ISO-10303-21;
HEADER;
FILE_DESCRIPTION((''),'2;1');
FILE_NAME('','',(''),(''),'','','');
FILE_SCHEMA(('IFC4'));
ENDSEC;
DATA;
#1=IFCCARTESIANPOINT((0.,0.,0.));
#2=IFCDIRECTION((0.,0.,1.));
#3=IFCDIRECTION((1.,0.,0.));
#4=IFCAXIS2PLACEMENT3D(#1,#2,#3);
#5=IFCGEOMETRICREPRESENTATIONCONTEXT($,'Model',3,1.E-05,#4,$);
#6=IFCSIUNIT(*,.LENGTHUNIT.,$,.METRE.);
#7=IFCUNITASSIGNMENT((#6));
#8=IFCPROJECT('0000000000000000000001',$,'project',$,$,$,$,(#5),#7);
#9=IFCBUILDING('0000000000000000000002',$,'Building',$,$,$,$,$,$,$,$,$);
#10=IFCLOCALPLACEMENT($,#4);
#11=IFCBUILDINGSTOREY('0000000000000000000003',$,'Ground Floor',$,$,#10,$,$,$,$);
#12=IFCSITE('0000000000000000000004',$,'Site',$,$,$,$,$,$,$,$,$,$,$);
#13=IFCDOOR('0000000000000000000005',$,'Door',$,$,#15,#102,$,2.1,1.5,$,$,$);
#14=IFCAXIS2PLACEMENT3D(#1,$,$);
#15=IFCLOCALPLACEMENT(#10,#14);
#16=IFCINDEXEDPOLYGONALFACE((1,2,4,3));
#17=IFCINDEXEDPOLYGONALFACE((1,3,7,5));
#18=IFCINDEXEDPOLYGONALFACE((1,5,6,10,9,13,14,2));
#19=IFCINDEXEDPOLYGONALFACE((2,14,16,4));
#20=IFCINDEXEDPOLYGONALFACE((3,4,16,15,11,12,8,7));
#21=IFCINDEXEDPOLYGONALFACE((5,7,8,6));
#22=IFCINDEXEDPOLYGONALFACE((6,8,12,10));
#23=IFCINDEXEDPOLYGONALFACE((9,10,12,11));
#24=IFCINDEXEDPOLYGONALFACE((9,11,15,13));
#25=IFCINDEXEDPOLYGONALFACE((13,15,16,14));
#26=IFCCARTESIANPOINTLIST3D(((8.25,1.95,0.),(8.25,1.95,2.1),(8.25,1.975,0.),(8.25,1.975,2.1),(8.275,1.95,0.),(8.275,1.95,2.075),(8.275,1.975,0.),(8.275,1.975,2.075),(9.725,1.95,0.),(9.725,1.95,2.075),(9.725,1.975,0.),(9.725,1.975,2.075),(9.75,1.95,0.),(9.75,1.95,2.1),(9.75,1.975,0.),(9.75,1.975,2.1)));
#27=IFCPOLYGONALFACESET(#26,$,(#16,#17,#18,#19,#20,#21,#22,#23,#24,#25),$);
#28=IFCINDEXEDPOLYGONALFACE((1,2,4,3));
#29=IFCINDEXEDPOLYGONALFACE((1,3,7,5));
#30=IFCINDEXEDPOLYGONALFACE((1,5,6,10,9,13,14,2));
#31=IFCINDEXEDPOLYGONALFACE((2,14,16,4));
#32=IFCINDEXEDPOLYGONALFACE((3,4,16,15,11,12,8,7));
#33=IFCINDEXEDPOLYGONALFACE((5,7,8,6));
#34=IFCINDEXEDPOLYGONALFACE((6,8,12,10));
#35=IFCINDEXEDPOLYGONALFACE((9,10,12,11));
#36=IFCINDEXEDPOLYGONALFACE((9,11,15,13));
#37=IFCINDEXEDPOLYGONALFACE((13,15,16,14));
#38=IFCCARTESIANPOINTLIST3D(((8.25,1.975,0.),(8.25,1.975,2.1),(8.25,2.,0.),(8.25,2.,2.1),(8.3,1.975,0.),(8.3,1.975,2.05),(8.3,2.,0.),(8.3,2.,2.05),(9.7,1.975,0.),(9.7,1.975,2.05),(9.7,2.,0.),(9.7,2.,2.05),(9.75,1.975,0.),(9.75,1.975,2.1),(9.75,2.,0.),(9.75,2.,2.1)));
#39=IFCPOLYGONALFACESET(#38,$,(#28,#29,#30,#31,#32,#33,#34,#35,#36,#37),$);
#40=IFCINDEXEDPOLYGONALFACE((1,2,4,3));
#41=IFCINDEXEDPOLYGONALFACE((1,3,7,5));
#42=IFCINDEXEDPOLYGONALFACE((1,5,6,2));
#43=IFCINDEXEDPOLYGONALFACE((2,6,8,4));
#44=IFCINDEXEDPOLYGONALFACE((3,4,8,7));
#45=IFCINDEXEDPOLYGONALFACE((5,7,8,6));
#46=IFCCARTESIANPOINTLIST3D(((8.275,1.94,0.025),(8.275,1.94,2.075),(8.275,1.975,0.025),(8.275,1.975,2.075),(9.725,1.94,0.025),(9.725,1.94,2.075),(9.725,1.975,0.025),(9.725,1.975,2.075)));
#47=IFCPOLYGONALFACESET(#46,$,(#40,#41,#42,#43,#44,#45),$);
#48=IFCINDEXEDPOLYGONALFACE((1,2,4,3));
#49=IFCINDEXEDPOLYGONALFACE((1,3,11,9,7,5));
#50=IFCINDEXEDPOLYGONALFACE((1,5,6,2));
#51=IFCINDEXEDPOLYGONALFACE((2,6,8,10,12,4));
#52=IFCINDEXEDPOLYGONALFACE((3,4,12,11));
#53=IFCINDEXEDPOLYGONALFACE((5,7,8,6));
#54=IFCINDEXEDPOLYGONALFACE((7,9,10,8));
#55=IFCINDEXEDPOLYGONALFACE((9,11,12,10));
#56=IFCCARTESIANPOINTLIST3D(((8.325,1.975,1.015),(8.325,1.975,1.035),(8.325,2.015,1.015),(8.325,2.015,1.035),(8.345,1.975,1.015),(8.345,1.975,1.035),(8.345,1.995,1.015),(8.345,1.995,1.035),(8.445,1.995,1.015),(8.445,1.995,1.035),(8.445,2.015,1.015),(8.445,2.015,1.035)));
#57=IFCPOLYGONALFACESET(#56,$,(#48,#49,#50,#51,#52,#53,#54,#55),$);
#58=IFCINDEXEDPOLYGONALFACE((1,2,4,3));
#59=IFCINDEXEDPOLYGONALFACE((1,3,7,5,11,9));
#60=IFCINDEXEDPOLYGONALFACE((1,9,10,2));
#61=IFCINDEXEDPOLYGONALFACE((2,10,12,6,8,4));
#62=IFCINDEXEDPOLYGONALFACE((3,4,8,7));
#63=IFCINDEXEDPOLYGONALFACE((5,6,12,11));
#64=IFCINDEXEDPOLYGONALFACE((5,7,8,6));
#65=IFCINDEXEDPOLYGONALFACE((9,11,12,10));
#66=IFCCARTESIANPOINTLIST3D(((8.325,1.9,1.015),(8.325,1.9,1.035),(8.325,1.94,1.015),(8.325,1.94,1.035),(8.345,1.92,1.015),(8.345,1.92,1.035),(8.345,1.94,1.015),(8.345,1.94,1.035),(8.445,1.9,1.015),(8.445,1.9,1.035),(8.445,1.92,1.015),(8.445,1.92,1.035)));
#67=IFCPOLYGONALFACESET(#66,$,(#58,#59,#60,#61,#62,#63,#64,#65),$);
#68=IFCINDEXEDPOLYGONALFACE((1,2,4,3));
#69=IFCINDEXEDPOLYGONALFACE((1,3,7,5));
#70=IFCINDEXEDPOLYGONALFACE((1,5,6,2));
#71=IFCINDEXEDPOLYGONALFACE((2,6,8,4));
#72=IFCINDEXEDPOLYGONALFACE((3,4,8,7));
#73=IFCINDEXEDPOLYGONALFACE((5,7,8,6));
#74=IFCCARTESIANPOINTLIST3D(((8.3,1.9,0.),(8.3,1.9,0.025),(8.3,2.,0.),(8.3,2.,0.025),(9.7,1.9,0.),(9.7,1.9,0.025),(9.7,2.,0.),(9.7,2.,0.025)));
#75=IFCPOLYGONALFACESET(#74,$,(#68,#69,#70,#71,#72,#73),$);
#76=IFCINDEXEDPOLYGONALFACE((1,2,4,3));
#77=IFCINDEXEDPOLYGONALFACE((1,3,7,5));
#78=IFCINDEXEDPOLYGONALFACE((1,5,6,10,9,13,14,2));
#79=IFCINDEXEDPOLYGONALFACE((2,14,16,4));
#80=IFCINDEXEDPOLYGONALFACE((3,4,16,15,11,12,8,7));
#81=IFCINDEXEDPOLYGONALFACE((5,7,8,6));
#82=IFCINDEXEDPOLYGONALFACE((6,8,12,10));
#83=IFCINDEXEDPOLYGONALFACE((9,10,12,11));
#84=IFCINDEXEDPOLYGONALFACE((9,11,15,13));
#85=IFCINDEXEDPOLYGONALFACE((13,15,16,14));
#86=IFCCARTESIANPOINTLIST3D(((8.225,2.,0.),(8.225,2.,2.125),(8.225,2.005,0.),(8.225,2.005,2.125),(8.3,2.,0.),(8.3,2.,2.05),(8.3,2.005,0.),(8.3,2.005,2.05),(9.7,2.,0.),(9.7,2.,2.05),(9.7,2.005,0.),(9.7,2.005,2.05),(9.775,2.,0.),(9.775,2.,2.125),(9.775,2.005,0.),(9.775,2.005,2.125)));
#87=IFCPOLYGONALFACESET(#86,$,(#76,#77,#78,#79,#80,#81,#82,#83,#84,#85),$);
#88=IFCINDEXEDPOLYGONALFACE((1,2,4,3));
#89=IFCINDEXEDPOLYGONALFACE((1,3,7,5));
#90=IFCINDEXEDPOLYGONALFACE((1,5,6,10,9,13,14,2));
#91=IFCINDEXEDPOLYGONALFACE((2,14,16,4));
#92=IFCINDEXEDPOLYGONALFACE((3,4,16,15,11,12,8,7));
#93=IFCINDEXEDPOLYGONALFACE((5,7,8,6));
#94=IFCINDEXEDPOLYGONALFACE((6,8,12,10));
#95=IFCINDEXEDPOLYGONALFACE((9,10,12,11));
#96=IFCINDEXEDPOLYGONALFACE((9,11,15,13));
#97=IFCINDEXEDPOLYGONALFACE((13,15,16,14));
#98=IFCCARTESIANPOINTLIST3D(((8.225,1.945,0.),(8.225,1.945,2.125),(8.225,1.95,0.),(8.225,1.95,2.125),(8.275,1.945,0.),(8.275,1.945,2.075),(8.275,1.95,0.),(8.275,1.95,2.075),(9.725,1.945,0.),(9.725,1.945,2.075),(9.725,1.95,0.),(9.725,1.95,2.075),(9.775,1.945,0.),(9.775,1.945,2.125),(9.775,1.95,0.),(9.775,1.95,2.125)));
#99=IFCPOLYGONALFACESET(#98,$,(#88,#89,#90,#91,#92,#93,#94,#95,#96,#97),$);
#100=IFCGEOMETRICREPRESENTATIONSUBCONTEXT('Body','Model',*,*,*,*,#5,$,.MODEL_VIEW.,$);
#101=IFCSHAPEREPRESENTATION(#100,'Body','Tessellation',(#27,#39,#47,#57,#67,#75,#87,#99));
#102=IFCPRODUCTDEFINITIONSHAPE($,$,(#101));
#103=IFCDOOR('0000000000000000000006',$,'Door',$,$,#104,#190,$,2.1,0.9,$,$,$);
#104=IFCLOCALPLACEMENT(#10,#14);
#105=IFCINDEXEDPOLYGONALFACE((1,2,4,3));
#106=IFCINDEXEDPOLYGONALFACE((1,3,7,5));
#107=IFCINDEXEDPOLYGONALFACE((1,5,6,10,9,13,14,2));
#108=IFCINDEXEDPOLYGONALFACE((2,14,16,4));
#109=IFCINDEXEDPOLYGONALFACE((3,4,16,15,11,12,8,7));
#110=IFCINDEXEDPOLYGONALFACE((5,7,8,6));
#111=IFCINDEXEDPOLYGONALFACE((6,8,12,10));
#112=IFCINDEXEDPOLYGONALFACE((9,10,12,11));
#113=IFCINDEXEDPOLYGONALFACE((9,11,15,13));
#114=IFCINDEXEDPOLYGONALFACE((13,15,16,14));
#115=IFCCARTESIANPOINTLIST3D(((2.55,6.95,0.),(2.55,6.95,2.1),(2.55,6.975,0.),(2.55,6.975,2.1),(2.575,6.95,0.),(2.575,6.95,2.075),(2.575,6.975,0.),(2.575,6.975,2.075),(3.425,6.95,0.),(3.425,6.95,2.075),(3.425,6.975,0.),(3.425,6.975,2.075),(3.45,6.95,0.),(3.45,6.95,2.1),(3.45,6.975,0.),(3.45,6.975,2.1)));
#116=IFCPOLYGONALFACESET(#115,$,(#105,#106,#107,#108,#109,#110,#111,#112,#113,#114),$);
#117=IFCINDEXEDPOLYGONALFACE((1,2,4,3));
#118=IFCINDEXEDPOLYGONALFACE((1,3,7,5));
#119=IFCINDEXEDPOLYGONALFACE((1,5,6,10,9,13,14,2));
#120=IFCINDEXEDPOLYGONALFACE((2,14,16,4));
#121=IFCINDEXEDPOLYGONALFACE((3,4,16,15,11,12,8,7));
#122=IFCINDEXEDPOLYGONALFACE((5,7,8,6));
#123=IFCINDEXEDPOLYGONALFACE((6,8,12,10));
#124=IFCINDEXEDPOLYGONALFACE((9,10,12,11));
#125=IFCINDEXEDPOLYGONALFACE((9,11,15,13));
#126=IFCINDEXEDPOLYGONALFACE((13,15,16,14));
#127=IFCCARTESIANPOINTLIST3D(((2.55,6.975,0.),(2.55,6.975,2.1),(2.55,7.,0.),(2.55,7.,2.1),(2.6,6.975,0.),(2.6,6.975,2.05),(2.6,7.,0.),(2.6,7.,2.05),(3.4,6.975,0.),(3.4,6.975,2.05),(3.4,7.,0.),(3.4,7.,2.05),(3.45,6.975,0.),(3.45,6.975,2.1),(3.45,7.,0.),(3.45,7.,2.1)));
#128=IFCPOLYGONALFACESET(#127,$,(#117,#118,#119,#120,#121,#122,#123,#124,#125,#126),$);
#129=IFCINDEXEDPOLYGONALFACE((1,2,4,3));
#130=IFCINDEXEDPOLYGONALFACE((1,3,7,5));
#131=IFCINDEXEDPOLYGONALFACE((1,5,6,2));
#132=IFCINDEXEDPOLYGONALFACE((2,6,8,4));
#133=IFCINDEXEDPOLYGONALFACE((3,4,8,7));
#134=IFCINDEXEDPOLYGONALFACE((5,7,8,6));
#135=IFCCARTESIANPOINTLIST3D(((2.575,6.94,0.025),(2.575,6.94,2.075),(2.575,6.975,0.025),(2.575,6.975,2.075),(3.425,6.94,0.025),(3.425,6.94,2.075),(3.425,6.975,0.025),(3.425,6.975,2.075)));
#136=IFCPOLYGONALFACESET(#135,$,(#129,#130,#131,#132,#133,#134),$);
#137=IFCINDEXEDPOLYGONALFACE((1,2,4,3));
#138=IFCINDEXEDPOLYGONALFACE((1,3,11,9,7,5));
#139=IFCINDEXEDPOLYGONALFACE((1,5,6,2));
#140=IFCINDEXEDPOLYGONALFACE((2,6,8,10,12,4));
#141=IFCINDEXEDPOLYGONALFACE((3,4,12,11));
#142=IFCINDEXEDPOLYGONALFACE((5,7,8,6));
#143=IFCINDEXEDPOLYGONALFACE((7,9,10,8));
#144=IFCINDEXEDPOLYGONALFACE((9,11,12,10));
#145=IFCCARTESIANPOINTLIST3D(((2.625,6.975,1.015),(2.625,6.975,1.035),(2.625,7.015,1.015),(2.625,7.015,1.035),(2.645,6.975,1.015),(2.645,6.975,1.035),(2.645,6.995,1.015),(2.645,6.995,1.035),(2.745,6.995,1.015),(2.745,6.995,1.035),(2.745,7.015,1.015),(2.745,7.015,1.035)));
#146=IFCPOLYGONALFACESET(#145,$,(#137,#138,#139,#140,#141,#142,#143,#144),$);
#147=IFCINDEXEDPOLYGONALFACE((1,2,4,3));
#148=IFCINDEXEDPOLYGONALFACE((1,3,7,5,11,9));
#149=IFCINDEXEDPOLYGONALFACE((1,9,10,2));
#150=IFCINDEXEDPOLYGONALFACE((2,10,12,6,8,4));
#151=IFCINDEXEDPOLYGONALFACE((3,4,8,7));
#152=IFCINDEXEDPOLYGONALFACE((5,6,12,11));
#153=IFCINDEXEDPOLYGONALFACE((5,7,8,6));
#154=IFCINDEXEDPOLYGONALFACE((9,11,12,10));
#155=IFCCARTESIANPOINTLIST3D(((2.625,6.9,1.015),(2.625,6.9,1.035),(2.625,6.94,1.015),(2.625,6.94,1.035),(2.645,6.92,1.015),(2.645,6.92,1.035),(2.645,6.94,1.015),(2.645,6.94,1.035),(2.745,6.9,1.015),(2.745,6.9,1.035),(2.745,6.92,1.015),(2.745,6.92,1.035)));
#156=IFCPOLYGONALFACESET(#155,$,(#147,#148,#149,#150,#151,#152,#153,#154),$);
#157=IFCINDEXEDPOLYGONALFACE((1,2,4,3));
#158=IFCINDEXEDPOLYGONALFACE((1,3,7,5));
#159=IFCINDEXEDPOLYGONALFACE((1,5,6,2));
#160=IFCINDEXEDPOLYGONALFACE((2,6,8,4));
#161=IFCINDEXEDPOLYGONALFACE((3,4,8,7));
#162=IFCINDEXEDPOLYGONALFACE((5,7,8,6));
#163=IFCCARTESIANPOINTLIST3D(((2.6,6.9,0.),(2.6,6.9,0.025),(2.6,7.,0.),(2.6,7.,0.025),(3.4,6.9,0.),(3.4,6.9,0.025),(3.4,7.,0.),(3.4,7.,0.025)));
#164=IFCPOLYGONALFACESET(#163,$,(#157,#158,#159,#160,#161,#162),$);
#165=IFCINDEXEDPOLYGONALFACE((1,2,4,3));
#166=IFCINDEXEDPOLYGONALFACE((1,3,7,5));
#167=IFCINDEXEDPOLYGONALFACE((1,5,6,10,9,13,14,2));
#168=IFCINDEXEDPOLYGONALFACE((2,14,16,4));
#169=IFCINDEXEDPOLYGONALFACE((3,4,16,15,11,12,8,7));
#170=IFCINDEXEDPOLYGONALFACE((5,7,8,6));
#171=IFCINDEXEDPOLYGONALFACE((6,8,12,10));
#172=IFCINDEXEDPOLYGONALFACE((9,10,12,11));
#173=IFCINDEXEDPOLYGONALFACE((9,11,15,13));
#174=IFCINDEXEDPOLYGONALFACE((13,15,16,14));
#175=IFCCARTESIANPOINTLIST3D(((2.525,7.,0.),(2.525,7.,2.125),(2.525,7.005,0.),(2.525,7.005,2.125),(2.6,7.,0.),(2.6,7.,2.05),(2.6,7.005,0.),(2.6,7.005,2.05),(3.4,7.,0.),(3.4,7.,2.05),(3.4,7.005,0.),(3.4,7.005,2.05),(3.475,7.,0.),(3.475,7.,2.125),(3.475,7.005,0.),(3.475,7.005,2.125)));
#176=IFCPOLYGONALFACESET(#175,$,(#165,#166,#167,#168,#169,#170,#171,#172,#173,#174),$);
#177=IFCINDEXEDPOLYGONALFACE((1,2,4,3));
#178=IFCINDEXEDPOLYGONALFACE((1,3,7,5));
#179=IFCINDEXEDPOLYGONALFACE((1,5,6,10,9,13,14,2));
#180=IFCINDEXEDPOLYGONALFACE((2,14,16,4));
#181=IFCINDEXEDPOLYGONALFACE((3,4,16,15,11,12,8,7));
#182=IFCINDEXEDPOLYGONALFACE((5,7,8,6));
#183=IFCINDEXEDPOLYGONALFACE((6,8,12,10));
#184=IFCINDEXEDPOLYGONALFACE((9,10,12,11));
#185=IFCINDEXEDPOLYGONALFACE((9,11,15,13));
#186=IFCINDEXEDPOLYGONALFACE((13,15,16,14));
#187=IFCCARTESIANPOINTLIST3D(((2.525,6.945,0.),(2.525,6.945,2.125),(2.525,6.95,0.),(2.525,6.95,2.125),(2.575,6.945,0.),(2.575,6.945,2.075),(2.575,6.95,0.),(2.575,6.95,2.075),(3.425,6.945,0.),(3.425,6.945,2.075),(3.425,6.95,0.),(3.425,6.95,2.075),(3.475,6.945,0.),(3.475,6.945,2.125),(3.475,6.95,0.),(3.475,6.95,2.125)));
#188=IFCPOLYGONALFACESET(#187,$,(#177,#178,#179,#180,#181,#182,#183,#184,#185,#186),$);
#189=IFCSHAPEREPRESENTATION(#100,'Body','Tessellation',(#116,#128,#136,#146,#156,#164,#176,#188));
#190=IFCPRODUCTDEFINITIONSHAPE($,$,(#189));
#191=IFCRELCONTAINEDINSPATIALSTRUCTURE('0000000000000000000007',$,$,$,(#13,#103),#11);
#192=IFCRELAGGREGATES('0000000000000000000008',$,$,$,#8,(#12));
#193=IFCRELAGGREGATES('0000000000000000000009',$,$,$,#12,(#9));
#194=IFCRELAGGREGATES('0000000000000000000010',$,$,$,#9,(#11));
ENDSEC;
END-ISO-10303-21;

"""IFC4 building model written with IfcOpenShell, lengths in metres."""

from ifc_helpers import new_model, si_unit, frame, origin_with_axes, place, context, subcontext, project, spatial, line, indexed_curve, outline, extrude, element, save


model = new_model("IFC4")

# Units and contexts
model_context = context("Model", 3, precision=1e-05, world=origin_with_axes())
body_context = subcontext(model_context, "Body", "Model", "MODEL_VIEW")
ifc_project = project(units=[si_unit("LENGTHUNIT", "METRE")], contexts=[model_context])

# Site, building, storey
site = spatial("IfcSite", under=ifc_project, Name="Site")
building = spatial("IfcBuilding", under=site, Name="Building")
storey_placement = place(None, origin_with_axes())
storey = spatial("IfcBuildingStorey", under=building, at=storey_placement, Name="Ground Floor")

# Doors
door_1_placement = place(storey_placement, frame((9.75, 2.0, 0.0), z_axis=(0.0, 0.0, 1.0), x_axis=(-1.0, 0.0, 0.0)))
element("IfcDoor", 1, at=door_1_placement, inside=storey, Name="Door", OverallHeight=2.1, OverallWidth=1.5, context=body_context, shape_type="SweptSolid", body=[
    extrude(outline(indexed_curve([(0.0, 0.0), (0.0, 2.1), (1.5, 2.1), (1.5, 0.0), (1.475, 0.0), (1.475, 2.075), (0.025, 2.075), (0.025, 0.0)], segments=[line(1, 2, 3, 4, 5, 6, 7, 8, 1)])), frame((0.0, 0.025, 0.0), z_axis=(0.0, -1.0, 0.0), x_axis=(1.0, 0.0, 0.0)), (0.0, 0.0, -1.0), 0.025),
    extrude(outline(indexed_curve([(0.0, 0.0), (0.0, 2.1), (1.5, 2.1), (1.5, 0.0), (1.45, 0.0), (1.45, 2.05), (0.05, 2.05), (0.05, 0.0)], segments=[line(1, 2, 3, 4, 5, 6, 7, 8, 1)])), frame((0.0, 0.0, 0.0), z_axis=(0.0, -1.0, 0.0), x_axis=(1.0, 0.0, 0.0)), (0.0, 0.0, -1.0), 0.025),
    extrude(outline(indexed_curve([(0.0, 0.0), (1.45, 0.0), (1.45, 0.035), (0.0, 0.035)], segments=[line(1, 2, 3, 4, 1)])), frame((0.025, 0.025, 0.025), z_axis=(0.0, 0.0, 1.0), x_axis=(1.0, 0.0, 0.0)), (0.0, 0.0, 1.0), 2.05),
    extrude(outline(indexed_curve([(0.0, 0.0), (0.0, -0.04), (-0.12, -0.04), (-0.12, -0.02), (-0.02, -0.02), (-0.02, 0.0)], segments=[line(1, 2, 3, 4, 5, 6, 1)])), frame((1.425, 0.025, 1.015), z_axis=(0.0, 0.0, 1.0), x_axis=(1.0, 0.0, 0.0)), (0.0, 0.0, 1.0), 0.02),
    extrude(outline(indexed_curve([(0.0, 0.0), (0.0, 0.04), (-0.12, 0.04), (-0.12, 0.02), (-0.02, 0.02), (-0.02, 0.0)], segments=[line(1, 2, 3, 4, 5, 6, 1)])), frame((1.425, 0.06, 1.015), z_axis=(0.0, 0.0, 1.0), x_axis=(1.0, 0.0, 0.0)), (0.0, 0.0, 1.0), 0.02),
    extrude(outline(indexed_curve([(0.0, 0.0), (1.4, 0.0), (1.4, 0.1), (0.0, 0.1)], segments=[line(1, 2, 3, 4, 1)])), frame((0.05, 0.0, 0.0), z_axis=(0.0, 0.0, 1.0), x_axis=(1.0, 0.0, 0.0)), (0.0, 0.0, 1.0), 0.025),
    extrude(outline(indexed_curve([(0.0, 0.0), (0.0, 2.125), (1.55, 2.125), (1.55, 0.0), (1.475, 0.0), (1.475, 2.05), (0.075, 2.05), (0.075, 0.0)], segments=[line(1, 2, 3, 4, 5, 6, 7, 8, 1)])), frame((-0.025, -0.005, 0.0), z_axis=(0.0, -1.0, 0.0), x_axis=(1.0, 0.0, 0.0)), (0.0, 0.0, -1.0), 0.005),
    extrude(outline(indexed_curve([(0.0, 0.0), (0.0, 2.125), (1.55, 2.125), (1.55, 0.0), (1.5, 0.0), (1.5, 2.075), (0.05, 2.075), (0.05, 0.0)], segments=[line(1, 2, 3, 4, 5, 6, 7, 8, 1)])), frame((-0.025, 0.05, 0.0), z_axis=(0.0, -1.0, 0.0), x_axis=(1.0, 0.0, 0.0)), (0.0, 0.0, -1.0), 0.005),
])
door_2_placement = place(storey_placement, frame((3.45, 7.0, 0.0), z_axis=(0.0, 0.0, 1.0), x_axis=(-1.0, 0.0, 0.0)))
element("IfcDoor", 2, at=door_2_placement, inside=storey, Name="Door", OverallHeight=2.1, OverallWidth=0.9, context=body_context, shape_type="SweptSolid", body=[
    extrude(outline(indexed_curve([(0.0, 0.0), (0.0, 2.1), (0.9, 2.1), (0.9, 0.0), (0.875, 0.0), (0.875, 2.075), (0.025, 2.075), (0.025, 0.0)], segments=[line(1, 2, 3, 4, 5, 6, 7, 8, 1)])), frame((0.0, 0.025, 0.0), z_axis=(0.0, -1.0, 0.0), x_axis=(1.0, 0.0, 0.0)), (0.0, 0.0, -1.0), 0.025),
    extrude(outline(indexed_curve([(0.0, 0.0), (0.0, 2.1), (0.9, 2.1), (0.9, 0.0), (0.85, 0.0), (0.85, 2.05), (0.05, 2.05), (0.05, 0.0)], segments=[line(1, 2, 3, 4, 5, 6, 7, 8, 1)])), frame((0.0, 0.0, 0.0), z_axis=(0.0, -1.0, 0.0), x_axis=(1.0, 0.0, 0.0)), (0.0, 0.0, -1.0), 0.025),
    extrude(outline(indexed_curve([(0.0, 0.0), (0.85, 0.0), (0.85, 0.035), (0.0, 0.035)], segments=[line(1, 2, 3, 4, 1)])), frame((0.025, 0.025, 0.025), z_axis=(0.0, 0.0, 1.0), x_axis=(1.0, 0.0, 0.0)), (0.0, 0.0, 1.0), 2.05),
    extrude(outline(indexed_curve([(0.0, 0.0), (0.0, -0.04), (-0.12, -0.04), (-0.12, -0.02), (-0.02, -0.02), (-0.02, 0.0)], segments=[line(1, 2, 3, 4, 5, 6, 1)])), frame((0.825, 0.025, 1.015), z_axis=(0.0, 0.0, 1.0), x_axis=(1.0, 0.0, 0.0)), (0.0, 0.0, 1.0), 0.02),
    extrude(outline(indexed_curve([(0.0, 0.0), (0.0, 0.04), (-0.12, 0.04), (-0.12, 0.02), (-0.02, 0.02), (-0.02, 0.0)], segments=[line(1, 2, 3, 4, 5, 6, 1)])), frame((0.825, 0.06, 1.015), z_axis=(0.0, 0.0, 1.0), x_axis=(1.0, 0.0, 0.0)), (0.0, 0.0, 1.0), 0.02),
    extrude(outline(indexed_curve([(0.0, 0.0), (0.8, 0.0), (0.8, 0.1), (0.0, 0.1)], segments=[line(1, 2, 3, 4, 1)])), frame((0.05, 0.0, 0.0), z_axis=(0.0, 0.0, 1.0), x_axis=(1.0, 0.0, 0.0)), (0.0, 0.0, 1.0), 0.025),
    extrude(outline(indexed_curve([(0.0, 0.0), (0.0, 2.125), (0.95, 2.125), (0.95, 0.0), (0.875, 0.0), (0.875, 2.05), (0.075, 2.05), (0.075, 0.0)], segments=[line(1, 2, 3, 4, 5, 6, 7, 8, 1)])), frame((-0.025, -0.005, 0.0), z_axis=(0.0, -1.0, 0.0), x_axis=(1.0, 0.0, 0.0)), (0.0, 0.0, -1.0), 0.005),
    extrude(outline(indexed_curve([(0.0, 0.0), (0.0, 2.125), (0.95, 2.125), (0.95, 0.0), (0.9, 0.0), (0.9, 2.075), (0.05, 2.075), (0.05, 0.0)], segments=[line(1, 2, 3, 4, 5, 6, 7, 8, 1)])), frame((-0.025, 0.05, 0.0), z_axis=(0.0, -1.0, 0.0), x_axis=(1.0, 0.0, 0.0)), (0.0, 0.0, -1.0), 0.005),
])

save(model, "model.ifc")
